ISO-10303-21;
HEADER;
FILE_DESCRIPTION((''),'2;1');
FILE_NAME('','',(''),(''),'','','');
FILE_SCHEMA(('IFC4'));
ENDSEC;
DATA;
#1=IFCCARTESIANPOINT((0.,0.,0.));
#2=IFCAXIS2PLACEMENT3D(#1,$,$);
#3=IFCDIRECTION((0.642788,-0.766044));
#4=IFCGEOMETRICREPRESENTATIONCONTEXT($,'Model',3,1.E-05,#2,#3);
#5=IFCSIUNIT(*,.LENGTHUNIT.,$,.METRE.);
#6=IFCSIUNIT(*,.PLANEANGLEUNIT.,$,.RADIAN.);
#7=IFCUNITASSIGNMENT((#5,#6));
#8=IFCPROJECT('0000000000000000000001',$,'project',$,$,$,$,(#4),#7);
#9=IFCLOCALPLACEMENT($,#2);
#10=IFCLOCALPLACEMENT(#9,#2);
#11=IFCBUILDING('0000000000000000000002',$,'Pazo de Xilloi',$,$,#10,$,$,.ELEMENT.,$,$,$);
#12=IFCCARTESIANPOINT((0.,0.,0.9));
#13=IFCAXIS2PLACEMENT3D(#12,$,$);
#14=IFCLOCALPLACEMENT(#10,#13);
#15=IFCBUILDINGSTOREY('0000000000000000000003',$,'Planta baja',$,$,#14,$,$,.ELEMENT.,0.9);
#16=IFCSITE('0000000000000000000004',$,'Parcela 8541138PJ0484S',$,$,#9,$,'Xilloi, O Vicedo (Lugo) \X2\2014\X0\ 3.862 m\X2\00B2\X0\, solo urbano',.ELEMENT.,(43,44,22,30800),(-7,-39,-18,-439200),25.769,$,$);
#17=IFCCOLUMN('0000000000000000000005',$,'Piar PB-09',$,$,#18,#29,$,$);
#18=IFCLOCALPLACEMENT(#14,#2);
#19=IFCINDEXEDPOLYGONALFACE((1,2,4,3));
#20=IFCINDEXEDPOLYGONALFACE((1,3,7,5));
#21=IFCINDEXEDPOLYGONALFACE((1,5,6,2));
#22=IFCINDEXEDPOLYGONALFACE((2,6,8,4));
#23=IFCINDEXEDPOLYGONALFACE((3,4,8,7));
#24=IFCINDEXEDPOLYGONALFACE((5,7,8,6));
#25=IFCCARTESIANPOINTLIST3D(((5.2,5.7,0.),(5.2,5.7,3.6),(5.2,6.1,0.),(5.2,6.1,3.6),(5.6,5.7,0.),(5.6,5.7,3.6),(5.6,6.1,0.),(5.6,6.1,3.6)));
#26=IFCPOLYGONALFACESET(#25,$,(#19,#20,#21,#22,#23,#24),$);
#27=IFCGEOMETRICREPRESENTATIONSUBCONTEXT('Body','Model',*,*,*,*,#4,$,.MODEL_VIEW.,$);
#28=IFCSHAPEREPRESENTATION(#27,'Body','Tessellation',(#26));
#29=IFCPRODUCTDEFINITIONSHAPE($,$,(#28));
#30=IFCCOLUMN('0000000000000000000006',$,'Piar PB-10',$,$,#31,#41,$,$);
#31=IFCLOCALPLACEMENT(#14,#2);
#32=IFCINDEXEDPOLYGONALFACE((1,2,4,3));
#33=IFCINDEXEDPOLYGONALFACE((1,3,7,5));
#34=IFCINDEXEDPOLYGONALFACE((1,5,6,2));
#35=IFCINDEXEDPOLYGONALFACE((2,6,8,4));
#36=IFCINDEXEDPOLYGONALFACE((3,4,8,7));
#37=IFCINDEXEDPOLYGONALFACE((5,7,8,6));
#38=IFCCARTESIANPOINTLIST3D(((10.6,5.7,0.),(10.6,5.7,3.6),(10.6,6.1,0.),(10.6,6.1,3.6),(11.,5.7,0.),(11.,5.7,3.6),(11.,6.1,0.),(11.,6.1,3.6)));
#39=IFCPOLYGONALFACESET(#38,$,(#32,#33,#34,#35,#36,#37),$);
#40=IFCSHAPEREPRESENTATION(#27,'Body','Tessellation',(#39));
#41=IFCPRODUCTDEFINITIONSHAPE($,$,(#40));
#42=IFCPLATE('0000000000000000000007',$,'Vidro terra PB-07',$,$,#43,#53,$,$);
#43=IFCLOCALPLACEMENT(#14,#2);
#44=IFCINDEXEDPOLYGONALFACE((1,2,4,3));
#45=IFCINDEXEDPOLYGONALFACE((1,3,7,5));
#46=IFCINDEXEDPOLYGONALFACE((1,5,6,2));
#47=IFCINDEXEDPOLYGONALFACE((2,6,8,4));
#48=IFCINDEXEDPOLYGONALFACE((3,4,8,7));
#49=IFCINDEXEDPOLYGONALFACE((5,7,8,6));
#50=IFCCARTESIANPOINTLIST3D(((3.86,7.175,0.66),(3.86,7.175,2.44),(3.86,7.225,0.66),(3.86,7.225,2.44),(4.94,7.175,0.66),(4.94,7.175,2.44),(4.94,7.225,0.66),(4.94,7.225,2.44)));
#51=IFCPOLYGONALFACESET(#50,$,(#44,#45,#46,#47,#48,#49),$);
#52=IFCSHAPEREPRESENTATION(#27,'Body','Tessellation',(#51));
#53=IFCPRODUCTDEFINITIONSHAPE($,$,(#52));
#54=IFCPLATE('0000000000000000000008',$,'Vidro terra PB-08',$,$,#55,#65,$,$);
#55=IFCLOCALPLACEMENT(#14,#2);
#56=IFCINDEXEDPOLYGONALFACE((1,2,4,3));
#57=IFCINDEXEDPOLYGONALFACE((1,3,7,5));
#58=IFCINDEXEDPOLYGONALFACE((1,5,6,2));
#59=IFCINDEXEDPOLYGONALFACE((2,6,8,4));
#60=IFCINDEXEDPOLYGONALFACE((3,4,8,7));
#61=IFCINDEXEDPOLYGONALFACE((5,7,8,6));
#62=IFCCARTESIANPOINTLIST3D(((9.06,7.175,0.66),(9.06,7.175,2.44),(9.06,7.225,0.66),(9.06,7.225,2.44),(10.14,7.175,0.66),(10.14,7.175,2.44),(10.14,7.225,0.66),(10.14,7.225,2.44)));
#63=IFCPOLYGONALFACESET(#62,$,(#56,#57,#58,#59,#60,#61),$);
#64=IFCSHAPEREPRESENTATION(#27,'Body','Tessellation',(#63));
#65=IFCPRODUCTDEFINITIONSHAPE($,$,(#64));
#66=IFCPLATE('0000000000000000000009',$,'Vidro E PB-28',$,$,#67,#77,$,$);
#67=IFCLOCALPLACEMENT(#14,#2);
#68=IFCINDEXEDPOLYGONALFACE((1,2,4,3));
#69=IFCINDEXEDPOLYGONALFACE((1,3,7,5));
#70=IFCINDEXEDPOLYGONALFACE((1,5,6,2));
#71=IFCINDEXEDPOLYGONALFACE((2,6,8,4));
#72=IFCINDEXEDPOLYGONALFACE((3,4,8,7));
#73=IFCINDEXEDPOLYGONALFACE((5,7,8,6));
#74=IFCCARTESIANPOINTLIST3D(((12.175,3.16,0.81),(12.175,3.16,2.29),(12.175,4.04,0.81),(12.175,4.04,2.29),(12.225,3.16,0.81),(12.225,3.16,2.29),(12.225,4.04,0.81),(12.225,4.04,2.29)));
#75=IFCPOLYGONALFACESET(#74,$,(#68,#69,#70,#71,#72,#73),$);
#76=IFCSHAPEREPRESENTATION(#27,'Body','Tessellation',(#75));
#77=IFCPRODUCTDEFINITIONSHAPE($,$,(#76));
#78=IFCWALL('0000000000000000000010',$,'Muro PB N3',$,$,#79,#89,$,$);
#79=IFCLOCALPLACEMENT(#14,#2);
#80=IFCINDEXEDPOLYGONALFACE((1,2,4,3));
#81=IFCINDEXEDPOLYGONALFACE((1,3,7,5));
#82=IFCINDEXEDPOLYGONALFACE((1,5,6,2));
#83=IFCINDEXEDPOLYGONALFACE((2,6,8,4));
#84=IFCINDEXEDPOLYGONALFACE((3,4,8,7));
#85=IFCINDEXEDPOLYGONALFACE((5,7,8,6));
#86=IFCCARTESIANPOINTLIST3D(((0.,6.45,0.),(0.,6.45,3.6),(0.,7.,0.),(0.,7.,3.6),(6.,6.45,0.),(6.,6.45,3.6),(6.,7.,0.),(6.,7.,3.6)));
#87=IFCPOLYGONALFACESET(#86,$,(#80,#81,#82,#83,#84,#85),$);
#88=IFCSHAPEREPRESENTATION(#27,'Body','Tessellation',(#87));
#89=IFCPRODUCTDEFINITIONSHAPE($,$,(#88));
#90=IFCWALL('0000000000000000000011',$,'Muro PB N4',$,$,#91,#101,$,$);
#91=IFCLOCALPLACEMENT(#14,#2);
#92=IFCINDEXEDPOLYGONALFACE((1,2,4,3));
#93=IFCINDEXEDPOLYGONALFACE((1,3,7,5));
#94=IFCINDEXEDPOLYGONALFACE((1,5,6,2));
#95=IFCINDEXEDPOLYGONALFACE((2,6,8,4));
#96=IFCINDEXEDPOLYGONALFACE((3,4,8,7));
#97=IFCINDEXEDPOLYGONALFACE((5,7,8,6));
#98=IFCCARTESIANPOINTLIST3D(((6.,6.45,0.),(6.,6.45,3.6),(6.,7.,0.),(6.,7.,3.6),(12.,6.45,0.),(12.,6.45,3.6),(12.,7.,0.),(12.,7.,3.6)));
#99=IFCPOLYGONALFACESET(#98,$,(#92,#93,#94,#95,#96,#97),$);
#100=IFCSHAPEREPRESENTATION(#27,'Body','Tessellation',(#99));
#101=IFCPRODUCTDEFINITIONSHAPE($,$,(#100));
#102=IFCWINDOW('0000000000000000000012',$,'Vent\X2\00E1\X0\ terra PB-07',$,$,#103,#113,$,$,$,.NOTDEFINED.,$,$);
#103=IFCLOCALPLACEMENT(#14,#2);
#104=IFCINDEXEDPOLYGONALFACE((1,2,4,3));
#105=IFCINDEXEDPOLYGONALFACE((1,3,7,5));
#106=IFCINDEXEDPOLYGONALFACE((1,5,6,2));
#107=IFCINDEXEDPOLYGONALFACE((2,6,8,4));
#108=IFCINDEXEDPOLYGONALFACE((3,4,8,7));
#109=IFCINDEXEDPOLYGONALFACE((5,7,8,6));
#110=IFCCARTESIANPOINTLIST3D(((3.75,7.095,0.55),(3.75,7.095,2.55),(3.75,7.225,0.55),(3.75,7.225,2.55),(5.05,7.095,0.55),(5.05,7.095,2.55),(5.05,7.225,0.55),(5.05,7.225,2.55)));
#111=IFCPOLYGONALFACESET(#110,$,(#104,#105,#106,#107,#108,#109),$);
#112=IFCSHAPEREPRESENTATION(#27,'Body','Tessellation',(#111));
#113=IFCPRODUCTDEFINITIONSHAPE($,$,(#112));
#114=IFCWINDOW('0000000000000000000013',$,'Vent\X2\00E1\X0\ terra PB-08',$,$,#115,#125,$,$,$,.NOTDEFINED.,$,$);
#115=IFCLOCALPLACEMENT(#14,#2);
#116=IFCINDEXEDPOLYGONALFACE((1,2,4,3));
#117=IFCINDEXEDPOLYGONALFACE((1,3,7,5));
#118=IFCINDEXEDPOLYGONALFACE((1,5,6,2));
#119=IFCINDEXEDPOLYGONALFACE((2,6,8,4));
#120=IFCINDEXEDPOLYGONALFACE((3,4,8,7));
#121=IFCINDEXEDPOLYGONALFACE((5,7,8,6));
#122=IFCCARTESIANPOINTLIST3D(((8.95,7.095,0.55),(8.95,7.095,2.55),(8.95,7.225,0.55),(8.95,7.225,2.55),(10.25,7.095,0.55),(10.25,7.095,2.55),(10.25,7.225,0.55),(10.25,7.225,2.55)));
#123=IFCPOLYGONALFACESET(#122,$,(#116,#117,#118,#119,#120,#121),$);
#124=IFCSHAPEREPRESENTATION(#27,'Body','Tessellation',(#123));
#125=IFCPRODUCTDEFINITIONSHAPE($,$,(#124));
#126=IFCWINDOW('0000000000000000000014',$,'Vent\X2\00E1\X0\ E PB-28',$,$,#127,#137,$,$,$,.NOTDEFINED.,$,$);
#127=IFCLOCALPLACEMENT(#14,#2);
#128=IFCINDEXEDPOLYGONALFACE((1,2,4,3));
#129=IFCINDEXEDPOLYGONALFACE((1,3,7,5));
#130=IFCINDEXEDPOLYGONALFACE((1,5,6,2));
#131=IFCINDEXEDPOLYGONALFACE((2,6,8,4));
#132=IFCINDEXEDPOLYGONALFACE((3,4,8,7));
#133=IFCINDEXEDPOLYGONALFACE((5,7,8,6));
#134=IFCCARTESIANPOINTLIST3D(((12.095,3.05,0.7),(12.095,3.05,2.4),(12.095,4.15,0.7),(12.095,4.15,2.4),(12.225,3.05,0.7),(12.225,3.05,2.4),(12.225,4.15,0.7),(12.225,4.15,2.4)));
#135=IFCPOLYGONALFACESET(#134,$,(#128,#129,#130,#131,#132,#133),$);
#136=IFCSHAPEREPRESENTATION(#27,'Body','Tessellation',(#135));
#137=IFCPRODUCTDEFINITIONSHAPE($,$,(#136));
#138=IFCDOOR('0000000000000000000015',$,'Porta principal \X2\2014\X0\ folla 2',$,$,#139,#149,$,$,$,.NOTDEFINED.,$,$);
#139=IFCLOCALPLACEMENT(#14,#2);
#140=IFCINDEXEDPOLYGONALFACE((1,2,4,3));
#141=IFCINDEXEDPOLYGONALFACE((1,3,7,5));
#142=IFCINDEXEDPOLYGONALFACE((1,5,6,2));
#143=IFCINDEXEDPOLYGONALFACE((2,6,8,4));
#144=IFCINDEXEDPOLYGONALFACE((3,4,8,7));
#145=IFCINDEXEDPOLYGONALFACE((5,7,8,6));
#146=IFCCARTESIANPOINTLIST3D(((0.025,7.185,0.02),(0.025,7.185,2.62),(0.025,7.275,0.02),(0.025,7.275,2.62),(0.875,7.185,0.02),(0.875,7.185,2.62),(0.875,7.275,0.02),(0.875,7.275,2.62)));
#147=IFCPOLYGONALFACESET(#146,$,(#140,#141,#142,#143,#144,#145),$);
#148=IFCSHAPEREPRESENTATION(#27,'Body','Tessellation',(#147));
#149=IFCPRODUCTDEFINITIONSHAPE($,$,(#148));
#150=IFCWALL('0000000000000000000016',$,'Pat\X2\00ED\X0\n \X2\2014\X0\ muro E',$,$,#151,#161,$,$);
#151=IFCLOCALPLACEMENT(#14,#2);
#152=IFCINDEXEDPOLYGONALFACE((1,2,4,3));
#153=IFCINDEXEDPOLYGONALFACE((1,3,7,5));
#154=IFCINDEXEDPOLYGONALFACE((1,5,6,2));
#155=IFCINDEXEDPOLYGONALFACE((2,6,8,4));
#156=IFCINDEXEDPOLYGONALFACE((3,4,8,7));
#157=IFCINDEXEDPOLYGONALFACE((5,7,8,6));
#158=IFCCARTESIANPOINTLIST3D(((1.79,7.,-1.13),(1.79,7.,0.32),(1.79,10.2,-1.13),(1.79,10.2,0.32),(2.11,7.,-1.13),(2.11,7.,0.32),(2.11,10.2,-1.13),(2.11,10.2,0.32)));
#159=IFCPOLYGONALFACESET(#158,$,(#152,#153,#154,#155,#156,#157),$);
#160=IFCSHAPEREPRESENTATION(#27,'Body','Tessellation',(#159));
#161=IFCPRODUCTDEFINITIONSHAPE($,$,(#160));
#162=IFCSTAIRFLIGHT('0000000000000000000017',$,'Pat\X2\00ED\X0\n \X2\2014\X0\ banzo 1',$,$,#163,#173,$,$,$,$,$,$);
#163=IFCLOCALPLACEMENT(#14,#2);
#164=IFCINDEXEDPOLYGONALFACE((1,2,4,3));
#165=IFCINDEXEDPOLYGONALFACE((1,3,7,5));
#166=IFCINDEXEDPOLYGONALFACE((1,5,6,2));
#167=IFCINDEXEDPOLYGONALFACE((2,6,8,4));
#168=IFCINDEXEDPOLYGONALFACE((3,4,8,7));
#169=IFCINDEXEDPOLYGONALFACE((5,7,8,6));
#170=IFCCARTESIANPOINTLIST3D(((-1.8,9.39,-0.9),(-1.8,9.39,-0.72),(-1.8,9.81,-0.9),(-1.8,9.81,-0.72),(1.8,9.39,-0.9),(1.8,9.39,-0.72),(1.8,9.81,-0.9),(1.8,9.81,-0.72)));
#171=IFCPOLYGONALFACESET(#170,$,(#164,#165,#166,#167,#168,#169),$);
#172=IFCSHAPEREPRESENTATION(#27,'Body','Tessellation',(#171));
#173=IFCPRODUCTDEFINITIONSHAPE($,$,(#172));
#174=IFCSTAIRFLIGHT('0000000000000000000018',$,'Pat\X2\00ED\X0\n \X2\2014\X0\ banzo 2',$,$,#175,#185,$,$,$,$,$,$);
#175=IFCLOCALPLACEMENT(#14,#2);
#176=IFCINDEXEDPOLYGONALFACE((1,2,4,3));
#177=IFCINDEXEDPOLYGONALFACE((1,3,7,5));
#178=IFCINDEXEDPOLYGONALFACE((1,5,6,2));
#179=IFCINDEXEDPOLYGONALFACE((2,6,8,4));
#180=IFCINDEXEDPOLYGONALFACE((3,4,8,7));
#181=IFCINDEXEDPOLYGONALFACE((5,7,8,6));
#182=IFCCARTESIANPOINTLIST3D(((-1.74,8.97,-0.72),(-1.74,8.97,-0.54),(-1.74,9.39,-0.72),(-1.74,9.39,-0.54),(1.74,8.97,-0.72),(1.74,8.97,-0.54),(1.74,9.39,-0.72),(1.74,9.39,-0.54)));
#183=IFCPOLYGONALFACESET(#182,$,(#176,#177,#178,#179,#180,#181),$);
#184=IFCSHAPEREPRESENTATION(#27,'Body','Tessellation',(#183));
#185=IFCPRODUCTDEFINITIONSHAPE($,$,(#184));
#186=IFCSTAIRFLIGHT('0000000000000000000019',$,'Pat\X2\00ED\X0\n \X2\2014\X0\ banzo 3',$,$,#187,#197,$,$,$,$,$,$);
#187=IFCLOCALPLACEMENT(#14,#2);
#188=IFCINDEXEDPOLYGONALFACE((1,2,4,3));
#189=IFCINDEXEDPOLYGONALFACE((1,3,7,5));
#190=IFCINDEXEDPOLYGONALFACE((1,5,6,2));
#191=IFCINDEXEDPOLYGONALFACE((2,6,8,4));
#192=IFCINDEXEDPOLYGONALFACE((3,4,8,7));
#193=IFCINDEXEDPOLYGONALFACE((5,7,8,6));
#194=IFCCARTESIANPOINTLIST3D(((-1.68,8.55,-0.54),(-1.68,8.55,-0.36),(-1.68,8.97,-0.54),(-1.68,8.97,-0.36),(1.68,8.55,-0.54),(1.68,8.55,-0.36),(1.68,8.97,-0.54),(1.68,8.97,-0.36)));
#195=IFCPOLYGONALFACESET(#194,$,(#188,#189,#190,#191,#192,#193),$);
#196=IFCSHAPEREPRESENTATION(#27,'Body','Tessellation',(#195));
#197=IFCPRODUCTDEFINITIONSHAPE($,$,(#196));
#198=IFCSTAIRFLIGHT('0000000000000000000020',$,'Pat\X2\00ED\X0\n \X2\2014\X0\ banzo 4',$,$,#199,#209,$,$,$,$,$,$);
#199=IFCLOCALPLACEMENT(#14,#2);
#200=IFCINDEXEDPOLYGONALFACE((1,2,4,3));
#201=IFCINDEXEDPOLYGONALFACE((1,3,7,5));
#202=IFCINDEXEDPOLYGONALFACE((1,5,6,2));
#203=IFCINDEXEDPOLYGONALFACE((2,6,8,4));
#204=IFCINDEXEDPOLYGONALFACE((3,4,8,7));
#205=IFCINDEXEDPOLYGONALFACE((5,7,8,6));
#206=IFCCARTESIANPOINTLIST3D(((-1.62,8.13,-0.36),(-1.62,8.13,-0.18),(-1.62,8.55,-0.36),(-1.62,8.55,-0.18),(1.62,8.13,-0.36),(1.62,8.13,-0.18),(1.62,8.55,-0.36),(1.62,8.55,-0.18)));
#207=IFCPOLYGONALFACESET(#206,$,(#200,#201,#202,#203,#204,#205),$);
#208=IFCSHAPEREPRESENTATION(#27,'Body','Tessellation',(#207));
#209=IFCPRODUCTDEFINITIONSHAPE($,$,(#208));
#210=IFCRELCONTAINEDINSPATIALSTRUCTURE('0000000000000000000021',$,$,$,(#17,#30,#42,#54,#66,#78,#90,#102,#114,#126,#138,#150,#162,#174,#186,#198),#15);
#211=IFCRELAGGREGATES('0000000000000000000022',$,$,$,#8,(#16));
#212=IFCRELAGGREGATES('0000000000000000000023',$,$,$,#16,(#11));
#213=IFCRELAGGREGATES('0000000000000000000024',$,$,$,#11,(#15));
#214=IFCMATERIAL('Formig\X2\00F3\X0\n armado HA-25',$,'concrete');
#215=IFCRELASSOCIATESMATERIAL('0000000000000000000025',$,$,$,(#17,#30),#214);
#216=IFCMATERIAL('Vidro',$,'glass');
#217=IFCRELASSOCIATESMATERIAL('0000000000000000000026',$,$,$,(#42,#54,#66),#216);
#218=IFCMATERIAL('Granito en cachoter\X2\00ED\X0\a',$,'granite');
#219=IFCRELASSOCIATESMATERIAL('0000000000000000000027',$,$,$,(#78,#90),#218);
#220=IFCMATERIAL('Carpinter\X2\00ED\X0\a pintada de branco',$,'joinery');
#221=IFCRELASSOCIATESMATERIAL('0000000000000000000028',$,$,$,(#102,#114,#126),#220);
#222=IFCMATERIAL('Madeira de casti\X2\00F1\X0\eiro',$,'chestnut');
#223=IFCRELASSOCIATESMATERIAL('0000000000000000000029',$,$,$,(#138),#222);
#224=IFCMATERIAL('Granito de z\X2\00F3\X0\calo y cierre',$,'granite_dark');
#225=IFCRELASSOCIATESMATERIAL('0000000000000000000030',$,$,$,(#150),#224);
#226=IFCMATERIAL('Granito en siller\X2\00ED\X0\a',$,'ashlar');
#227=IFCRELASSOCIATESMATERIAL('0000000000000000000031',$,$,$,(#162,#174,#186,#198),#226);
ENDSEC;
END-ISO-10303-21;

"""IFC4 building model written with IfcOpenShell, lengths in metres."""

from ifc_helpers import new_model, si_unit, direction, frame, origin, origin_2d, place, context, subcontext, project, spatial, rectangle, extrude, material, element, save


model = new_model("IFC4")

# Units and contexts
model_context = context("Model", 3, precision=1e-05, world=origin(), true_north=direction((0.642788, -0.766044)))
body_context = subcontext(model_context, "Body", "Model", "MODEL_VIEW")
ifc_project = project(units=[si_unit("LENGTHUNIT", "METRE"), si_unit("PLANEANGLEUNIT", "RADIAN")], contexts=[model_context])

# Site, building, storey
site_placement = place(None, origin())
site = spatial("IfcSite", under=ifc_project, at=site_placement, Name="Parcela 8541138PJ0484S", LongName="Xilloi, O Vicedo (Lugo) — 3.862 m², solo urbano", CompositionType="ELEMENT", RefLatitude=(43, 44, 22, 30800), RefLongitude=(-7, -39, -18, -439200), RefElevation=25.769)
building_placement = place(site_placement, origin())
building = spatial("IfcBuilding", under=site, at=building_placement, Name="Pazo de Xilloi", CompositionType="ELEMENT")
storey_placement = place(building_placement, frame((0.0, 0.0, 0.9)))
storey = spatial("IfcBuildingStorey", under=building, at=storey_placement, Name="Planta baja", CompositionType="ELEMENT", Elevation=0.9)

# Columns
ifc_material_1 = material(Name="Formigón armado HA-25", Category="concrete")
for number, where, name in (
    (1, (5.4, 5.9, 1.8), "Piar PB-09"),
    (2, (10.8, 5.9, 1.8), "Piar PB-10"),
):
    element("IfcColumn", number, at=place(storey_placement, frame(where)), inside=storey, material=ifc_material_1, Name=name, context=body_context, shape_type="SweptSolid", body=[
        extrude(rectangle(XDim=0.4, YDim=0.4, at=origin_2d()), frame((0.0, 0.0, -1.8)), (0.0, 0.0, 1.0), 3.6),
    ])

# Plates
ifc_material_2 = material(Name="Vidro", Category="glass")
for number, where, name in (
    (3, (4.4, 7.2, 1.55), "Vidro terra PB-07"),
    (4, (9.6, 7.2, 1.55), "Vidro terra PB-08"),
):
    element("IfcPlate", number, at=place(storey_placement, frame(where)), inside=storey, material=ifc_material_2, Name=name, context=body_context, shape_type="SweptSolid", body=[
        extrude(rectangle(XDim=1.08, YDim=0.05, at=origin_2d()), frame((0.0, 0.0, -0.89)), (0.0, 0.0, 1.0), 1.78),
    ])
plate_placement = place(storey_placement, frame((12.2, 3.6, 1.55)))
element("IfcPlate", 5, at=plate_placement, inside=storey, material=ifc_material_2, Name="Vidro E PB-28", context=body_context, shape_type="SweptSolid", body=[
    extrude(rectangle(XDim=0.05, YDim=0.88, at=origin_2d()), frame((0.0, 0.0, -0.74)), (0.0, 0.0, 1.0), 1.48),
])

# Walls
ifc_material_3 = material(Name="Granito en cachotería", Category="granite")
for number, where, name in (
    (6, (3.0, 6.725, 1.8), "Muro PB N3"),
    (7, (9.0, 6.725, 1.8), "Muro PB N4"),
):
    element("IfcWall", number, at=place(storey_placement, frame(where)), inside=storey, material=ifc_material_3, Name=name, context=body_context, shape_type="SweptSolid", body=[
        extrude(rectangle(XDim=6.0, YDim=0.55, at=origin_2d()), frame((0.0, 0.0, -1.8)), (0.0, 0.0, 1.0), 3.6),
    ])

# Windows
ifc_material_4 = material(Name="Carpintería pintada de branco", Category="joinery")
for number, where, name in (
    (8, (4.4, 7.16, 1.55), "Ventá terra PB-07"),
    (9, (9.6, 7.16, 1.55), "Ventá terra PB-08"),
):
    element("IfcWindow", number, at=place(storey_placement, frame(where)), inside=storey, material=ifc_material_4, Name=name, PredefinedType="NOTDEFINED", context=body_context, shape_type="SweptSolid", body=[
        extrude(rectangle(XDim=1.3, YDim=0.13, at=origin_2d()), frame((0.0, 0.0, -1.0)), (0.0, 0.0, 1.0), 2.0),
    ])
window_placement = place(storey_placement, frame((12.16, 3.6, 1.55)))
element("IfcWindow", 10, at=window_placement, inside=storey, material=ifc_material_4, Name="Ventá E PB-28", PredefinedType="NOTDEFINED", context=body_context, shape_type="SweptSolid", body=[
    extrude(rectangle(XDim=0.13, YDim=1.1, at=origin_2d()), frame((0.0, 0.0, -0.85)), (0.0, 0.0, 1.0), 1.7),
])

# Door
ifc_material_5 = material(Name="Madeira de castiñeiro", Category="chestnut")
door_placement = place(storey_placement, frame((0.45, 7.23, 1.32)))
element("IfcDoor", 11, at=door_placement, inside=storey, material=ifc_material_5, Name="Porta principal — folla 2", PredefinedType="NOTDEFINED", context=body_context, shape_type="SweptSolid", body=[
    extrude(rectangle(XDim=0.85, YDim=0.09, at=origin_2d()), frame((0.0, 0.0, -1.3)), (0.0, 0.0, 1.0), 2.6),
])

# Wall
ifc_material_6 = material(Name="Granito de zócalo y cierre", Category="granite_dark")
wall_placement = place(storey_placement, frame((1.95, 8.6, -0.405)))
element("IfcWall", 12, at=wall_placement, inside=storey, material=ifc_material_6, Name="Patín — muro E", context=body_context, shape_type="SweptSolid", body=[
    extrude(rectangle(XDim=0.32, YDim=3.2, at=origin_2d()), frame((0.0, 0.0, -0.725)), (0.0, 0.0, 1.0), 1.45),
])

# Stair flights
ifc_material_7 = material(Name="Granito en sillería", Category="ashlar")
stair_flight_1_placement = place(storey_placement, frame((0.0, 9.6, -0.81)))
element("IfcStairFlight", 13, at=stair_flight_1_placement, inside=storey, material=ifc_material_7, Name="Patín — banzo 1", context=body_context, shape_type="SweptSolid", body=[
    extrude(rectangle(XDim=3.6, YDim=0.42, at=origin_2d()), frame((0.0, 0.0, -0.09)), (0.0, 0.0, 1.0), 0.18),
])
stair_flight_2_placement = place(storey_placement, frame((0.0, 9.18, -0.63)))
element("IfcStairFlight", 14, at=stair_flight_2_placement, inside=storey, material=ifc_material_7, Name="Patín — banzo 2", context=body_context, shape_type="SweptSolid", body=[
    extrude(rectangle(XDim=3.48, YDim=0.42, at=origin_2d()), frame((0.0, 0.0, -0.09)), (0.0, 0.0, 1.0), 0.18),
])
stair_flight_3_placement = place(storey_placement, frame((0.0, 8.76, -0.45)))
element("IfcStairFlight", 15, at=stair_flight_3_placement, inside=storey, material=ifc_material_7, Name="Patín — banzo 3", context=body_context, shape_type="SweptSolid", body=[
    extrude(rectangle(XDim=3.36, YDim=0.42, at=origin_2d()), frame((0.0, 0.0, -0.09)), (0.0, 0.0, 1.0), 0.18),
])
stair_flight_4_placement = place(storey_placement, frame((0.0, 8.34, -0.27)))
element("IfcStairFlight", 16, at=stair_flight_4_placement, inside=storey, material=ifc_material_7, Name="Patín — banzo 4", context=body_context, shape_type="SweptSolid", body=[
    extrude(rectangle(XDim=3.24, YDim=0.42, at=origin_2d()), frame((0.0, 0.0, -0.09)), (0.0, 0.0, 1.0), 0.18),
])

save(model, "model.ifc")
